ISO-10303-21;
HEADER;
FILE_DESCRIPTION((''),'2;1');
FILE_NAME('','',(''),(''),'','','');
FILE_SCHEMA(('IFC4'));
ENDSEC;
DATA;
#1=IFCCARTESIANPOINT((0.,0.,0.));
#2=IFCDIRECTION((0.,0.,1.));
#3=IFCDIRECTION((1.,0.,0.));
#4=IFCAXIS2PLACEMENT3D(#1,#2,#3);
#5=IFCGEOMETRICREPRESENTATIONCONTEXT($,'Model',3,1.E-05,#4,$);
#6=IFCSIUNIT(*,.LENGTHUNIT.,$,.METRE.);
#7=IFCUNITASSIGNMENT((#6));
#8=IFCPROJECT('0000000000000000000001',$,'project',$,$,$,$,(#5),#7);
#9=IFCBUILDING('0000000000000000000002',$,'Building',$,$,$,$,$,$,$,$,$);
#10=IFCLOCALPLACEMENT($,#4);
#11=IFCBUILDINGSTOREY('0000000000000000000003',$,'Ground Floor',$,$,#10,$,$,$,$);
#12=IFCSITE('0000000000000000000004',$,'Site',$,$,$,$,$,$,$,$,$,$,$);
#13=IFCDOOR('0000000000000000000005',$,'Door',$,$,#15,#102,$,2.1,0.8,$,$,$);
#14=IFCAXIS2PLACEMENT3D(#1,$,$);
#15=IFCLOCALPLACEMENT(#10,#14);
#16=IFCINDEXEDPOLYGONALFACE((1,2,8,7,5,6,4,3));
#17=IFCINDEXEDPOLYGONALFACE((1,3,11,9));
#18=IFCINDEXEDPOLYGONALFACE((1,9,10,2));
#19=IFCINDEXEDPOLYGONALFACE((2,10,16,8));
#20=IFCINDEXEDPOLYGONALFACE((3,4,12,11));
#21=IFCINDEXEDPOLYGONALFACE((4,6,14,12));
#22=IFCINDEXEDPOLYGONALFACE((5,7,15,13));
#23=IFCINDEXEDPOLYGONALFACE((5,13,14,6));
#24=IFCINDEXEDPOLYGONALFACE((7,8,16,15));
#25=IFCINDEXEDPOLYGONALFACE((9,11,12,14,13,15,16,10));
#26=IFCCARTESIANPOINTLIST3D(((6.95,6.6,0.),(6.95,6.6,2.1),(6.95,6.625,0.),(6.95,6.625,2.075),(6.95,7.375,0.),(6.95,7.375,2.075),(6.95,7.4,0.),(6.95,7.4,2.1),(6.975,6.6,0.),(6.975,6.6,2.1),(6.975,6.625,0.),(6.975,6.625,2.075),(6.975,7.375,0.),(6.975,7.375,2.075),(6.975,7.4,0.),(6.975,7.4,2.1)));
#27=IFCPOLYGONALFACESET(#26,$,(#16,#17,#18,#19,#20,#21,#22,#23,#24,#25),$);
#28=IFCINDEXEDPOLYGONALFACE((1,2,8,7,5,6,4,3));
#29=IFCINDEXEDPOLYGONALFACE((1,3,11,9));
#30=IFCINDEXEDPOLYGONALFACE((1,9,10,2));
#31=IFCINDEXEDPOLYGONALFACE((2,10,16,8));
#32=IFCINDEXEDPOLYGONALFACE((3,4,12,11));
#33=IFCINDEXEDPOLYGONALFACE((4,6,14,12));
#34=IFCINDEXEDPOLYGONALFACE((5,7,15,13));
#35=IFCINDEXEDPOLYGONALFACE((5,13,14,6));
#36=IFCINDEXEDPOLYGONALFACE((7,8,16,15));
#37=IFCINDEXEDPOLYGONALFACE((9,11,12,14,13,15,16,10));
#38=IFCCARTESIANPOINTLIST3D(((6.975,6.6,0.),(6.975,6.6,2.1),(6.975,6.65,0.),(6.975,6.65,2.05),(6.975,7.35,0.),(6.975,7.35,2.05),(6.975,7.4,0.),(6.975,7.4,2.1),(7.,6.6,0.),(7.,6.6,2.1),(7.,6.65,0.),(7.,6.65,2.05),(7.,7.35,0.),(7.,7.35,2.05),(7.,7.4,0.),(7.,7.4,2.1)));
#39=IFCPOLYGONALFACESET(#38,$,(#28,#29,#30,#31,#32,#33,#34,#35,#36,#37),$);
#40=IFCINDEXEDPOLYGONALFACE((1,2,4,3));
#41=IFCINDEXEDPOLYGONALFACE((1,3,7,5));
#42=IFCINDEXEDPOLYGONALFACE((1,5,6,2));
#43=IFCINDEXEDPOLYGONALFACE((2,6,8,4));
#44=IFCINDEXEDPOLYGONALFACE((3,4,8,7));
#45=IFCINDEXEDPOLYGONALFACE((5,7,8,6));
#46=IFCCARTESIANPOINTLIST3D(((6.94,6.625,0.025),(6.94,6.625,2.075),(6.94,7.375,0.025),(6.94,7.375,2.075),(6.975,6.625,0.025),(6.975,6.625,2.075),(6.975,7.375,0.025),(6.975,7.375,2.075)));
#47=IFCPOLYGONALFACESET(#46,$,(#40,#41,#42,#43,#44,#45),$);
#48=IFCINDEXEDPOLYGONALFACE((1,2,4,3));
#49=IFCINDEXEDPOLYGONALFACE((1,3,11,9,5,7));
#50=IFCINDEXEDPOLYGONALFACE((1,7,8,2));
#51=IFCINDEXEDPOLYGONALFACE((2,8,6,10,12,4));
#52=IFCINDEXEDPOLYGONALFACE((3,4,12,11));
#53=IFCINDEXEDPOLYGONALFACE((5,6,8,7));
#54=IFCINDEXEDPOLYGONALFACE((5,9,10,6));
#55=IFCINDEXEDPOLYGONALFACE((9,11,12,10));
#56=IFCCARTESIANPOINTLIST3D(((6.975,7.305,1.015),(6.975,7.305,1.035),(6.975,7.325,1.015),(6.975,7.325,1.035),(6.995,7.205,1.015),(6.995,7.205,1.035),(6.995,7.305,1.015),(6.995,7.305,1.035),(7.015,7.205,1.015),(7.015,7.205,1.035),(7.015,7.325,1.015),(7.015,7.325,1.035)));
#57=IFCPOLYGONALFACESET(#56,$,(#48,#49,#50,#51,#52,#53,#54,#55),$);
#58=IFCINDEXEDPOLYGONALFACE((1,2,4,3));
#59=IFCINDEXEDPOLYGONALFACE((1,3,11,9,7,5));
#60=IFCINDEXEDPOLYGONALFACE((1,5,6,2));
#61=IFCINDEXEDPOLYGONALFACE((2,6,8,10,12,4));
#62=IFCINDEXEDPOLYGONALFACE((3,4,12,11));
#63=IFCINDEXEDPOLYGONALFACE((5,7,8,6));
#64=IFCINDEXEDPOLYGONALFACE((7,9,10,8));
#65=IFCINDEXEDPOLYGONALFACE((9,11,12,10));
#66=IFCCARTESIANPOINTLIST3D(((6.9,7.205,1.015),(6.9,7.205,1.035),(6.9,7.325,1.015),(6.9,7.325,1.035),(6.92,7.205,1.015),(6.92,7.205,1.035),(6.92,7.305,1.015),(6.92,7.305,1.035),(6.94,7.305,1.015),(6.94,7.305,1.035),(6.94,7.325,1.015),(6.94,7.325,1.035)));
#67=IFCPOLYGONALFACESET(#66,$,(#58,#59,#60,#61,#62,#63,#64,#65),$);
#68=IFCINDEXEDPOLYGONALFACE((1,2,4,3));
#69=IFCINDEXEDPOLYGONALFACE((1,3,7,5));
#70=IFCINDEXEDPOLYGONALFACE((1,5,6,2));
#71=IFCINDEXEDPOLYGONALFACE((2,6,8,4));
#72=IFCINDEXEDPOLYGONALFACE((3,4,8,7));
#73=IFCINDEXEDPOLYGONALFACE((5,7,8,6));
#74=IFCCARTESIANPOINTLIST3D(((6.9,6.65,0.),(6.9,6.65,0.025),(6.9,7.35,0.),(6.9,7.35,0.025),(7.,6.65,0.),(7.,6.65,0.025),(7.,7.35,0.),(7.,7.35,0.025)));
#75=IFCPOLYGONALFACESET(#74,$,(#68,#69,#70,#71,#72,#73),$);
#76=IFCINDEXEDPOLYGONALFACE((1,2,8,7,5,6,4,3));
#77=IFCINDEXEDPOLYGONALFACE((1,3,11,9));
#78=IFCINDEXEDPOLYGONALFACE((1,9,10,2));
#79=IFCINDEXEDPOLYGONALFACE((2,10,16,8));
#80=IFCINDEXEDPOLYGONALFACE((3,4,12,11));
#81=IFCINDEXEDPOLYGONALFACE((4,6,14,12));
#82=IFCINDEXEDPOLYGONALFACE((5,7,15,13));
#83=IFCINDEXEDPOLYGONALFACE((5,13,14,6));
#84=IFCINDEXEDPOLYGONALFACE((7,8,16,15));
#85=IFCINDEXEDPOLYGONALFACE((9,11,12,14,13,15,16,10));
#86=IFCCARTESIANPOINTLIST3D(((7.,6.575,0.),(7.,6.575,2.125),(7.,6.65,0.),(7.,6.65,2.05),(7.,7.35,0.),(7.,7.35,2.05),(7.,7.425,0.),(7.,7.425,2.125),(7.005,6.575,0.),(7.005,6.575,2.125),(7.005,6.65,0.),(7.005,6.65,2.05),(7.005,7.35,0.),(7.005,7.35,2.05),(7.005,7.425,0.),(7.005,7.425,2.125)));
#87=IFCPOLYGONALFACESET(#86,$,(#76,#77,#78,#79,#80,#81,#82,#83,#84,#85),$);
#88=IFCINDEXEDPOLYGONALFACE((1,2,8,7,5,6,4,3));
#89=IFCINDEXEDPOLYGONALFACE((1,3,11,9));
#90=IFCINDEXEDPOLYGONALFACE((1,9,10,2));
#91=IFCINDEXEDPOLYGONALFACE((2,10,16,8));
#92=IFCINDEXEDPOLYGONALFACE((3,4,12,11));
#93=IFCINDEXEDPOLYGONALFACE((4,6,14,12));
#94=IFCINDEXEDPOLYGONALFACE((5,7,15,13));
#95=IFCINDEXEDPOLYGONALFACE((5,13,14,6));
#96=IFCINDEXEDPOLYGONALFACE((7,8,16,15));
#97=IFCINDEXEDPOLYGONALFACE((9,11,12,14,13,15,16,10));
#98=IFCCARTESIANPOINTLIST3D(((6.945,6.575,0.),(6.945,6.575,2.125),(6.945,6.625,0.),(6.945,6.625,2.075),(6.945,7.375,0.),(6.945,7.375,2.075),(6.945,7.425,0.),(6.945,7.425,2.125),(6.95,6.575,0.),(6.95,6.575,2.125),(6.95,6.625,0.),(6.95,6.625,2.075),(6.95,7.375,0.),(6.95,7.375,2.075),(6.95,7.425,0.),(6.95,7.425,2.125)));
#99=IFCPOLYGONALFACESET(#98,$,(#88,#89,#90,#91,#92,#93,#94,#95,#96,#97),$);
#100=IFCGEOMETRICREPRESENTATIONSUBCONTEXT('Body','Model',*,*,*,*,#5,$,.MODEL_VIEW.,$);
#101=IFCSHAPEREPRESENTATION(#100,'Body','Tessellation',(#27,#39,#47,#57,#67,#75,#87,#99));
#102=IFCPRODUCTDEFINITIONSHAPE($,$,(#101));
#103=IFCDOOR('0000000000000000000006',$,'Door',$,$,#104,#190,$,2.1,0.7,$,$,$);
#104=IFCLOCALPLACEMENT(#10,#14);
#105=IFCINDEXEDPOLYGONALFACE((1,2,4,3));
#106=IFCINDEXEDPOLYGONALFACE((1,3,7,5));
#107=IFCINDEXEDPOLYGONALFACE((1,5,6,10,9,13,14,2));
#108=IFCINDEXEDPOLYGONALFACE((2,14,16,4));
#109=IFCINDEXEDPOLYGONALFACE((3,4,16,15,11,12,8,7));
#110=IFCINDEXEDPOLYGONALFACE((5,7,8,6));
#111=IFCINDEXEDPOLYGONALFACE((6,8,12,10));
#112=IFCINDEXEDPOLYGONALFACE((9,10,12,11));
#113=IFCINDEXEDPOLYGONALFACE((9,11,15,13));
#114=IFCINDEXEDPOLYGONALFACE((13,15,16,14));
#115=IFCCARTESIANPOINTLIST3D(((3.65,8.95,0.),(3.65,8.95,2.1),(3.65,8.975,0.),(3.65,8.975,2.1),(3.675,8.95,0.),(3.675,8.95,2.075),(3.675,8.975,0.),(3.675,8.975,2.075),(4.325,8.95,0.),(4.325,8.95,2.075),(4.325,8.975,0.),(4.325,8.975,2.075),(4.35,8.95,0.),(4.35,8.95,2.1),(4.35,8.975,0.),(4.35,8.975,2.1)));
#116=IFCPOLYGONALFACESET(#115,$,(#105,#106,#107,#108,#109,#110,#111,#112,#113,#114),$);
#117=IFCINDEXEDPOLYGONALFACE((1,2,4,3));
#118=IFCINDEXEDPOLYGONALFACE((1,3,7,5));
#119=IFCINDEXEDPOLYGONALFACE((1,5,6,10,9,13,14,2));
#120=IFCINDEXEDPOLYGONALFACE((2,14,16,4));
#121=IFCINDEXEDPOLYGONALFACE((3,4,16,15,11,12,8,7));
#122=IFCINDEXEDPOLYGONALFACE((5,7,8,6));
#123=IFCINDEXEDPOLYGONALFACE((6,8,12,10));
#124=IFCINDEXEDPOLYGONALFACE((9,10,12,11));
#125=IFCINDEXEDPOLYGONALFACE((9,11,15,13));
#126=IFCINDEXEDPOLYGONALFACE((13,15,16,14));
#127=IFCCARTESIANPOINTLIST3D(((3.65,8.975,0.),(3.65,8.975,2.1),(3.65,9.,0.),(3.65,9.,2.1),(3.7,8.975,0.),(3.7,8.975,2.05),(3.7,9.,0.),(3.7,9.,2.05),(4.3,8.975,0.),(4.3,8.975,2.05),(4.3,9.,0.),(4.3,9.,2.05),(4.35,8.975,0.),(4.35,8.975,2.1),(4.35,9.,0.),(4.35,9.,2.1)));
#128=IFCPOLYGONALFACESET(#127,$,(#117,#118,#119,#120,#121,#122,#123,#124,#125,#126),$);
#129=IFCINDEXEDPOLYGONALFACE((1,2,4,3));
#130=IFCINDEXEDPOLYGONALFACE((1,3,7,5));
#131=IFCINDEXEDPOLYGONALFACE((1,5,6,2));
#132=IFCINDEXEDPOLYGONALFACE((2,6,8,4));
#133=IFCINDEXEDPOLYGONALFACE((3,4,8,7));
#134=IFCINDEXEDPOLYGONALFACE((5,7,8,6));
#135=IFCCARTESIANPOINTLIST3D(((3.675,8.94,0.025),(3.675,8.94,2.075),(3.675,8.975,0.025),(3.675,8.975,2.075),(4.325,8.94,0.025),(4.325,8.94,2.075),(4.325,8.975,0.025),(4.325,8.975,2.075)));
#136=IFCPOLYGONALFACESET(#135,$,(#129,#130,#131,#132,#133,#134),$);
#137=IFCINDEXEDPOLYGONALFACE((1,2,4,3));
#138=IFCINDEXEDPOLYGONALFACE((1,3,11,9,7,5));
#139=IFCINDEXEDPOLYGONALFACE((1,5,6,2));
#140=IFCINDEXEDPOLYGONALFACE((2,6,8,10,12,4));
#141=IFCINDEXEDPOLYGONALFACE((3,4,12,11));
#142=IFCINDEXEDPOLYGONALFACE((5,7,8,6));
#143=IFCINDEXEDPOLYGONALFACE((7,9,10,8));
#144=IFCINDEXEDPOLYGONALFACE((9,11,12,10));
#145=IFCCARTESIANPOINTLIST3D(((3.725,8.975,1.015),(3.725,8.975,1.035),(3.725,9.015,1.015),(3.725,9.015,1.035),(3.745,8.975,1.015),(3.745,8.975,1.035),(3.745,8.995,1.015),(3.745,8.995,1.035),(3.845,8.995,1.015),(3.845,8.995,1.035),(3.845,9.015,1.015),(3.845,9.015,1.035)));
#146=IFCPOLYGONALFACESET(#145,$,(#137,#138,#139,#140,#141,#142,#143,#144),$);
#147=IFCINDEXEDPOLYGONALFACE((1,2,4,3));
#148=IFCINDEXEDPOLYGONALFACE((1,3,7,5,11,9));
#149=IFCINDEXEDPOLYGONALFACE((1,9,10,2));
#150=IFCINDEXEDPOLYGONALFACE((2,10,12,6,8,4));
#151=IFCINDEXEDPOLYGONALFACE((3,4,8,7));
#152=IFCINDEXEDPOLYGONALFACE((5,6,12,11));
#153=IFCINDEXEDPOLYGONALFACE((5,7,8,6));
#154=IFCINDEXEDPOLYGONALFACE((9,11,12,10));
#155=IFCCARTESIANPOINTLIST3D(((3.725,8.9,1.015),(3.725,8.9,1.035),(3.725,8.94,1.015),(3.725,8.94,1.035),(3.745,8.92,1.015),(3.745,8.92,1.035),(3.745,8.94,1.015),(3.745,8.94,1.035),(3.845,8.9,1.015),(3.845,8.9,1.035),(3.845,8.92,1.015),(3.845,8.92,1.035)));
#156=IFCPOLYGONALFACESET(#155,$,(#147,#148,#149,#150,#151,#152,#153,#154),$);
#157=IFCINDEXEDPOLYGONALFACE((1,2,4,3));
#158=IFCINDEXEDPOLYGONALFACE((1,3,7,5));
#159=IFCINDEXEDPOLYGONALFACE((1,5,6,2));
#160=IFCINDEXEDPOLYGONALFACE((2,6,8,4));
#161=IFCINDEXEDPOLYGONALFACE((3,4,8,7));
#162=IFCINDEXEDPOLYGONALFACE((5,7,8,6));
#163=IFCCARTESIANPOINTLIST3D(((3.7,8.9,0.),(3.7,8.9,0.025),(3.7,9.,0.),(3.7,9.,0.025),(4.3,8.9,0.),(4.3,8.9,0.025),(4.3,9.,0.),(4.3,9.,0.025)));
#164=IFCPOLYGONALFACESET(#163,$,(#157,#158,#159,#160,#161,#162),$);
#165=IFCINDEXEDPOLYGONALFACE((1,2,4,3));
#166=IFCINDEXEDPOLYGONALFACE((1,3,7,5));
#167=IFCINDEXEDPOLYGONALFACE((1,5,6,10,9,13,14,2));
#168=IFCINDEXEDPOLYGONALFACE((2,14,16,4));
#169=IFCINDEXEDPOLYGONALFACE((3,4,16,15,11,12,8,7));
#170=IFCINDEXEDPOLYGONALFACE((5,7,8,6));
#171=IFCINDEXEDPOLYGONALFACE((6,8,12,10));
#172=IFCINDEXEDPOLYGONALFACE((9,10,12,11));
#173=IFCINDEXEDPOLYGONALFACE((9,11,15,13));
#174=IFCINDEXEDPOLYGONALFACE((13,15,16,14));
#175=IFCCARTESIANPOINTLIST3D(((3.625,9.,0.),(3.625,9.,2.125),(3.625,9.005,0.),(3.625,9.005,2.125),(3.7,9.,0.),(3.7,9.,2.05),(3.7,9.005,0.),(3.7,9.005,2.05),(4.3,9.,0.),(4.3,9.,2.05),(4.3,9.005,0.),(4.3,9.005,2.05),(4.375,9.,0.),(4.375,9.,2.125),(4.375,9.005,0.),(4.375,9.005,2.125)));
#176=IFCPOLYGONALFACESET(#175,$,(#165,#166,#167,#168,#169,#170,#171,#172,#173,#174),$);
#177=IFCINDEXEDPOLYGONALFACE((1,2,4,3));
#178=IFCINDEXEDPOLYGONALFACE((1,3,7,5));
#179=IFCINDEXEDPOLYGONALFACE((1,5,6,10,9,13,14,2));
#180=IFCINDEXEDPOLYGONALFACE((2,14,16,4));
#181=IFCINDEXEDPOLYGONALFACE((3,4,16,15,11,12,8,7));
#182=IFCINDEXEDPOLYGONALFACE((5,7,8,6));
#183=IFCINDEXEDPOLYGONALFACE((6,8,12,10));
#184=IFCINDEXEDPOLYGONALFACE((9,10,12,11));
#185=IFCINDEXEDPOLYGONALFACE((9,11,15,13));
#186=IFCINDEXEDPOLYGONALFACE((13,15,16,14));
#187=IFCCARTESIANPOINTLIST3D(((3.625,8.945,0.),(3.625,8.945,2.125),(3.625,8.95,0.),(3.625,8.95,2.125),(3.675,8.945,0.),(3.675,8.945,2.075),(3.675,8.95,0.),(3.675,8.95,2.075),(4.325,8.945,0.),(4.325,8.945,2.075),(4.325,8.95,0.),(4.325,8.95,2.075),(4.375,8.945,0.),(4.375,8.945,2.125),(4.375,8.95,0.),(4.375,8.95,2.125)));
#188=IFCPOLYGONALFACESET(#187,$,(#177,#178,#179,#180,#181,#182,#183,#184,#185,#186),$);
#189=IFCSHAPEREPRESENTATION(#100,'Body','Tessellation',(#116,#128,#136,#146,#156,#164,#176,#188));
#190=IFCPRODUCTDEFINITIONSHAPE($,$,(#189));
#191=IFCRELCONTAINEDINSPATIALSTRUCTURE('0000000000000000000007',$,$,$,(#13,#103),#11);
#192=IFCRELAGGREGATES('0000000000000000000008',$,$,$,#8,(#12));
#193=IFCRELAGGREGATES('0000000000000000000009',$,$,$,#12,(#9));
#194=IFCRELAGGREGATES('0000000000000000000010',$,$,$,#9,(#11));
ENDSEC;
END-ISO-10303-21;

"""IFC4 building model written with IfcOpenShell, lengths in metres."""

from ifc_helpers import new_model, si_unit, frame, origin_with_axes, place, context, subcontext, project, spatial, line, indexed_curve, outline, extrude, element, save


model = new_model("IFC4")

# Units and contexts
model_context = context("Model", 3, precision=1e-05, world=origin_with_axes())
body_context = subcontext(model_context, "Body", "Model", "MODEL_VIEW")
ifc_project = project(units=[si_unit("LENGTHUNIT", "METRE")], contexts=[model_context])

# Site, building, storey
site = spatial("IfcSite", under=ifc_project, Name="Site")
building = spatial("IfcBuilding", under=site, Name="Building")
storey_placement = place(None, origin_with_axes())
storey = spatial("IfcBuildingStorey", under=building, at=storey_placement, Name="Ground Floor")

# Doors
door_1_placement = place(storey_placement, frame((7.0, 6.6, 0.0), z_axis=(0.0, 0.0, 1.0), x_axis=(0.0, 1.0, 0.0)))
element("IfcDoor", 1, at=door_1_placement, inside=storey, Name="Door", OverallHeight=2.1, OverallWidth=0.8, context=body_context, shape_type="SweptSolid", body=[
    extrude(outline(indexed_curve([(0.0, 0.0), (0.0, 2.1), (0.8, 2.1), (0.8, 0.0), (0.775, 0.0), (0.775, 2.075), (0.025, 2.075), (0.025, 0.0)], segments=[line(1, 2, 3, 4, 5, 6, 7, 8, 1)])), frame((0.0, 0.025, 0.0), z_axis=(0.0, -1.0, 0.0), x_axis=(1.0, 0.0, 0.0)), (0.0, 0.0, -1.0), 0.025),
    extrude(outline(indexed_curve([(0.0, 0.0), (0.0, 2.1), (0.8, 2.1), (0.8, 0.0), (0.75, 0.0), (0.75, 2.05), (0.05, 2.05), (0.05, 0.0)], segments=[line(1, 2, 3, 4, 5, 6, 7, 8, 1)])), frame((0.0, 0.0, 0.0), z_axis=(0.0, -1.0, 0.0), x_axis=(1.0, 0.0, 0.0)), (0.0, 0.0, -1.0), 0.025),
    extrude(outline(indexed_curve([(0.0, 0.0), (0.75, 0.0), (0.75, 0.035), (0.0, 0.035)], segments=[line(1, 2, 3, 4, 1)])), frame((0.025, 0.025, 0.025), z_axis=(0.0, 0.0, 1.0), x_axis=(1.0, 0.0, 0.0)), (0.0, 0.0, 1.0), 2.05),
    extrude(outline(indexed_curve([(0.0, 0.0), (0.0, -0.04), (-0.12, -0.04), (-0.12, -0.02), (-0.02, -0.02), (-0.02, 0.0)], segments=[line(1, 2, 3, 4, 5, 6, 1)])), frame((0.725, 0.025, 1.015), z_axis=(0.0, 0.0, 1.0), x_axis=(1.0, 0.0, 0.0)), (0.0, 0.0, 1.0), 0.02),
    extrude(outline(indexed_curve([(0.0, 0.0), (0.0, 0.04), (-0.12, 0.04), (-0.12, 0.02), (-0.02, 0.02), (-0.02, 0.0)], segments=[line(1, 2, 3, 4, 5, 6, 1)])), frame((0.725, 0.06, 1.015), z_axis=(0.0, 0.0, 1.0), x_axis=(1.0, 0.0, 0.0)), (0.0, 0.0, 1.0), 0.02),
    extrude(outline(indexed_curve([(0.0, 0.0), (0.7, 0.0), (0.7, 0.1), (0.0, 0.1)], segments=[line(1, 2, 3, 4, 1)])), frame((0.05, 0.0, 0.0), z_axis=(0.0, 0.0, 1.0), x_axis=(1.0, 0.0, 0.0)), (0.0, 0.0, 1.0), 0.025),
    extrude(outline(indexed_curve([(0.0, 0.0), (0.0, 2.125), (0.85, 2.125), (0.85, 0.0), (0.775, 0.0), (0.775, 2.05), (0.075, 2.05), (0.075, 0.0)], segments=[line(1, 2, 3, 4, 5, 6, 7, 8, 1)])), frame((-0.025, -0.005, 0.0), z_axis=(0.0, -1.0, 0.0), x_axis=(1.0, 0.0, 0.0)), (0.0, 0.0, -1.0), 0.005),
    extrude(outline(indexed_curve([(0.0, 0.0), (0.0, 2.125), (0.85, 2.125), (0.85, 0.0), (0.8, 0.0), (0.8, 2.075), (0.05, 2.075), (0.05, 0.0)], segments=[line(1, 2, 3, 4, 5, 6, 7, 8, 1)])), frame((-0.025, 0.05, 0.0), z_axis=(0.0, -1.0, 0.0), x_axis=(1.0, 0.0, 0.0)), (0.0, 0.0, -1.0), 0.005),
])
door_2_placement = place(storey_placement, frame((4.35, 9.0, 0.0), z_axis=(0.0, 0.0, 1.0), x_axis=(-1.0, 0.0, 0.0)))
element("IfcDoor", 2, at=door_2_placement, inside=storey, Name="Door", OverallHeight=2.1, OverallWidth=0.7, context=body_context, shape_type="SweptSolid", body=[
    extrude(outline(indexed_curve([(0.0, 0.0), (0.0, 2.1), (0.7, 2.1), (0.7, 0.0), (0.675, 0.0), (0.675, 2.075), (0.025, 2.075), (0.025, 0.0)], segments=[line(1, 2, 3, 4, 5, 6, 7, 8, 1)])), frame((0.0, 0.025, 0.0), z_axis=(0.0, -1.0, 0.0), x_axis=(1.0, 0.0, 0.0)), (0.0, 0.0, -1.0), 0.025),
    extrude(outline(indexed_curve([(0.0, 0.0), (0.0, 2.1), (0.7, 2.1), (0.7, 0.0), (0.65, 0.0), (0.65, 2.05), (0.05, 2.05), (0.05, 0.0)], segments=[line(1, 2, 3, 4, 5, 6, 7, 8, 1)])), frame((0.0, 0.0, 0.0), z_axis=(0.0, -1.0, 0.0), x_axis=(1.0, 0.0, 0.0)), (0.0, 0.0, -1.0), 0.025),
    extrude(outline(indexed_curve([(0.0, 0.0), (0.65, 0.0), (0.65, 0.035), (0.0, 0.035)], segments=[line(1, 2, 3, 4, 1)])), frame((0.025, 0.025, 0.025), z_axis=(0.0, 0.0, 1.0), x_axis=(1.0, 0.0, 0.0)), (0.0, 0.0, 1.0), 2.05),
    extrude(outline(indexed_curve([(0.0, 0.0), (0.0, -0.04), (-0.12, -0.04), (-0.12, -0.02), (-0.02, -0.02), (-0.02, 0.0)], segments=[line(1, 2, 3, 4, 5, 6, 1)])), frame((0.625, 0.025, 1.015), z_axis=(0.0, 0.0, 1.0), x_axis=(1.0, 0.0, 0.0)), (0.0, 0.0, 1.0), 0.02),
    extrude(outline(indexed_curve([(0.0, 0.0), (0.0, 0.04), (-0.12, 0.04), (-0.12, 0.02), (-0.02, 0.02), (-0.02, 0.0)], segments=[line(1, 2, 3, 4, 5, 6, 1)])), frame((0.625, 0.06, 1.015), z_axis=(0.0, 0.0, 1.0), x_axis=(1.0, 0.0, 0.0)), (0.0, 0.0, 1.0), 0.02),
    extrude(outline(indexed_curve([(0.0, 0.0), (0.6, 0.0), (0.6, 0.1), (0.0, 0.1)], segments=[line(1, 2, 3, 4, 1)])), frame((0.05, 0.0, 0.0), z_axis=(0.0, 0.0, 1.0), x_axis=(1.0, 0.0, 0.0)), (0.0, 0.0, 1.0), 0.025),
    extrude(outline(indexed_curve([(0.0, 0.0), (0.0, 2.125), (0.75, 2.125), (0.75, 0.0), (0.675, 0.0), (0.675, 2.05), (0.075, 2.05), (0.075, 0.0)], segments=[line(1, 2, 3, 4, 5, 6, 7, 8, 1)])), frame((-0.025, -0.005, 0.0), z_axis=(0.0, -1.0, 0.0), x_axis=(1.0, 0.0, 0.0)), (0.0, 0.0, -1.0), 0.005),
    extrude(outline(indexed_curve([(0.0, 0.0), (0.0, 2.125), (0.75, 2.125), (0.75, 0.0), (0.7, 0.0), (0.7, 2.075), (0.05, 2.075), (0.05, 0.0)], segments=[line(1, 2, 3, 4, 5, 6, 7, 8, 1)])), frame((-0.025, 0.05, 0.0), z_axis=(0.0, -1.0, 0.0), x_axis=(1.0, 0.0, 0.0)), (0.0, 0.0, -1.0), 0.005),
])

save(model, "model.ifc")
